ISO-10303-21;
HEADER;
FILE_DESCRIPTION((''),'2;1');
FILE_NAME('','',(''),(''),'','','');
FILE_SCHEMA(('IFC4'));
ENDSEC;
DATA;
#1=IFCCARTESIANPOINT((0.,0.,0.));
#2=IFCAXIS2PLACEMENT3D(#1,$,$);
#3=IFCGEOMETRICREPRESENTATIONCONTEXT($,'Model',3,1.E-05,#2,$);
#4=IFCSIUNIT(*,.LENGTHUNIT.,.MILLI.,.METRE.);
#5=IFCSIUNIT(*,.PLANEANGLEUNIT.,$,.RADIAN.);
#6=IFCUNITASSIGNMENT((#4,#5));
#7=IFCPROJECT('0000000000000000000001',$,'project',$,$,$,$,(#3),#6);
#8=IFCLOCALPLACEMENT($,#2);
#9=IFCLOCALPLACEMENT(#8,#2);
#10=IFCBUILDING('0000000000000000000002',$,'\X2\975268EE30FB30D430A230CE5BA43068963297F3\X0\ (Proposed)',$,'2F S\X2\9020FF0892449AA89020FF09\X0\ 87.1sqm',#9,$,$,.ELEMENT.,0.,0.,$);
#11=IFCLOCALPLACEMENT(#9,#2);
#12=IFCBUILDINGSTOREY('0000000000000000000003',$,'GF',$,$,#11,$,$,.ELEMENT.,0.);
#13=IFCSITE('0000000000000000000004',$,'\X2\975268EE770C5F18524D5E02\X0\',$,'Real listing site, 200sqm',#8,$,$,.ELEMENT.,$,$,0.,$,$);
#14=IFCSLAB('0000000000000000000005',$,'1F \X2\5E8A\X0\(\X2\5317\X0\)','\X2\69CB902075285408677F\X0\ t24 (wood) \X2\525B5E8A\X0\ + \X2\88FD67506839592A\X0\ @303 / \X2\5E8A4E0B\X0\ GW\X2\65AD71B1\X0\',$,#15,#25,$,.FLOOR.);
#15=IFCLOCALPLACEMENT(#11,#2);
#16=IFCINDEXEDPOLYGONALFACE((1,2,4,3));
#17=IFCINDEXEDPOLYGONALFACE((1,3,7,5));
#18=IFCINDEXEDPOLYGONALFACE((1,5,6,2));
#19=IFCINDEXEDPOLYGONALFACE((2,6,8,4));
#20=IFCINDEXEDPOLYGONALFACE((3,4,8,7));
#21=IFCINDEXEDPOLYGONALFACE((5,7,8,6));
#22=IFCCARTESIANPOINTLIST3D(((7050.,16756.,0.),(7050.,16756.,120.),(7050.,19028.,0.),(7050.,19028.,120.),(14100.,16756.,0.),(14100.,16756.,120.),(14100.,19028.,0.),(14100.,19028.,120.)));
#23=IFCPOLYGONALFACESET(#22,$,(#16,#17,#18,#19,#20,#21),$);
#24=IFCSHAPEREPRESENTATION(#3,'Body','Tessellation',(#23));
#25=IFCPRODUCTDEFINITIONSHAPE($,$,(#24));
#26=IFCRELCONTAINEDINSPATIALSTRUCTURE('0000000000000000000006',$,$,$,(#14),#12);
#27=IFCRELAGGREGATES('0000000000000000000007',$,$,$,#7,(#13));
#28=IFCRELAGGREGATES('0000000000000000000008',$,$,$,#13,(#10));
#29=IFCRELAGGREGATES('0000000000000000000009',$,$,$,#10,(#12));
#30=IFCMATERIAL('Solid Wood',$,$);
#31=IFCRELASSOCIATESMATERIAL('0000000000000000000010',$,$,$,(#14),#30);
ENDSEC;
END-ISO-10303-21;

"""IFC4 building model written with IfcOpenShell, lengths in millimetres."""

from ifc_helpers import new_model, si_unit, frame, frame_2d, origin, place, context, project, spatial, rectangle, extrude, material, element, save


model = new_model("IFC4")

# Units and contexts
model_context = context("Model", 3, precision=1e-05, world=origin())
ifc_project = project(units=[si_unit("LENGTHUNIT", "METRE", prefix="MILLI"), si_unit("PLANEANGLEUNIT", "RADIAN")], contexts=[model_context])

# Site, building, storey
site_placement = place(None, origin())
site = spatial("IfcSite", under=ifc_project, at=site_placement, Name="青森県弘前市", ObjectType="Real listing site, 200sqm", CompositionType="ELEMENT", RefElevation=0.0)
building_placement = place(site_placement, origin())
building = spatial("IfcBuilding", under=site, at=building_placement, Name="青森・ピアノ室と防音 (Proposed)", ObjectType="2F S造（鉄骨造） 87.1sqm", CompositionType="ELEMENT", ElevationOfRefHeight=0.0, ElevationOfTerrain=0.0)
storey_placement = place(building_placement, origin())
storey = spatial("IfcBuildingStorey", under=building, at=storey_placement, Name="GF", CompositionType="ELEMENT", Elevation=0.0)

# Shared definitions
ifc_material_1 = material(Name="Solid Wood")

# Slab
slab_placement = place(storey_placement, frame((3525.0, 8378.0, 0.0)))
element("IfcSlab", 1, at=slab_placement, inside=storey, material=ifc_material_1, Name="1F 床(北)", Description="構造用合板 t24 (wood) 剛床 + 製材根太 @303 / 床下 GW断熱", PredefinedType="FLOOR", context=model_context, shape_type="SweptSolid", body=[
    extrude(rectangle(XDim=7050.0, YDim=2272.0, at=frame_2d((3525.0, 1136.0))), frame((3525.0, 8378.0, 0.0)), (0.0, 0.0, 1.0), 120.0),
])

save(model, "model.ifc")
